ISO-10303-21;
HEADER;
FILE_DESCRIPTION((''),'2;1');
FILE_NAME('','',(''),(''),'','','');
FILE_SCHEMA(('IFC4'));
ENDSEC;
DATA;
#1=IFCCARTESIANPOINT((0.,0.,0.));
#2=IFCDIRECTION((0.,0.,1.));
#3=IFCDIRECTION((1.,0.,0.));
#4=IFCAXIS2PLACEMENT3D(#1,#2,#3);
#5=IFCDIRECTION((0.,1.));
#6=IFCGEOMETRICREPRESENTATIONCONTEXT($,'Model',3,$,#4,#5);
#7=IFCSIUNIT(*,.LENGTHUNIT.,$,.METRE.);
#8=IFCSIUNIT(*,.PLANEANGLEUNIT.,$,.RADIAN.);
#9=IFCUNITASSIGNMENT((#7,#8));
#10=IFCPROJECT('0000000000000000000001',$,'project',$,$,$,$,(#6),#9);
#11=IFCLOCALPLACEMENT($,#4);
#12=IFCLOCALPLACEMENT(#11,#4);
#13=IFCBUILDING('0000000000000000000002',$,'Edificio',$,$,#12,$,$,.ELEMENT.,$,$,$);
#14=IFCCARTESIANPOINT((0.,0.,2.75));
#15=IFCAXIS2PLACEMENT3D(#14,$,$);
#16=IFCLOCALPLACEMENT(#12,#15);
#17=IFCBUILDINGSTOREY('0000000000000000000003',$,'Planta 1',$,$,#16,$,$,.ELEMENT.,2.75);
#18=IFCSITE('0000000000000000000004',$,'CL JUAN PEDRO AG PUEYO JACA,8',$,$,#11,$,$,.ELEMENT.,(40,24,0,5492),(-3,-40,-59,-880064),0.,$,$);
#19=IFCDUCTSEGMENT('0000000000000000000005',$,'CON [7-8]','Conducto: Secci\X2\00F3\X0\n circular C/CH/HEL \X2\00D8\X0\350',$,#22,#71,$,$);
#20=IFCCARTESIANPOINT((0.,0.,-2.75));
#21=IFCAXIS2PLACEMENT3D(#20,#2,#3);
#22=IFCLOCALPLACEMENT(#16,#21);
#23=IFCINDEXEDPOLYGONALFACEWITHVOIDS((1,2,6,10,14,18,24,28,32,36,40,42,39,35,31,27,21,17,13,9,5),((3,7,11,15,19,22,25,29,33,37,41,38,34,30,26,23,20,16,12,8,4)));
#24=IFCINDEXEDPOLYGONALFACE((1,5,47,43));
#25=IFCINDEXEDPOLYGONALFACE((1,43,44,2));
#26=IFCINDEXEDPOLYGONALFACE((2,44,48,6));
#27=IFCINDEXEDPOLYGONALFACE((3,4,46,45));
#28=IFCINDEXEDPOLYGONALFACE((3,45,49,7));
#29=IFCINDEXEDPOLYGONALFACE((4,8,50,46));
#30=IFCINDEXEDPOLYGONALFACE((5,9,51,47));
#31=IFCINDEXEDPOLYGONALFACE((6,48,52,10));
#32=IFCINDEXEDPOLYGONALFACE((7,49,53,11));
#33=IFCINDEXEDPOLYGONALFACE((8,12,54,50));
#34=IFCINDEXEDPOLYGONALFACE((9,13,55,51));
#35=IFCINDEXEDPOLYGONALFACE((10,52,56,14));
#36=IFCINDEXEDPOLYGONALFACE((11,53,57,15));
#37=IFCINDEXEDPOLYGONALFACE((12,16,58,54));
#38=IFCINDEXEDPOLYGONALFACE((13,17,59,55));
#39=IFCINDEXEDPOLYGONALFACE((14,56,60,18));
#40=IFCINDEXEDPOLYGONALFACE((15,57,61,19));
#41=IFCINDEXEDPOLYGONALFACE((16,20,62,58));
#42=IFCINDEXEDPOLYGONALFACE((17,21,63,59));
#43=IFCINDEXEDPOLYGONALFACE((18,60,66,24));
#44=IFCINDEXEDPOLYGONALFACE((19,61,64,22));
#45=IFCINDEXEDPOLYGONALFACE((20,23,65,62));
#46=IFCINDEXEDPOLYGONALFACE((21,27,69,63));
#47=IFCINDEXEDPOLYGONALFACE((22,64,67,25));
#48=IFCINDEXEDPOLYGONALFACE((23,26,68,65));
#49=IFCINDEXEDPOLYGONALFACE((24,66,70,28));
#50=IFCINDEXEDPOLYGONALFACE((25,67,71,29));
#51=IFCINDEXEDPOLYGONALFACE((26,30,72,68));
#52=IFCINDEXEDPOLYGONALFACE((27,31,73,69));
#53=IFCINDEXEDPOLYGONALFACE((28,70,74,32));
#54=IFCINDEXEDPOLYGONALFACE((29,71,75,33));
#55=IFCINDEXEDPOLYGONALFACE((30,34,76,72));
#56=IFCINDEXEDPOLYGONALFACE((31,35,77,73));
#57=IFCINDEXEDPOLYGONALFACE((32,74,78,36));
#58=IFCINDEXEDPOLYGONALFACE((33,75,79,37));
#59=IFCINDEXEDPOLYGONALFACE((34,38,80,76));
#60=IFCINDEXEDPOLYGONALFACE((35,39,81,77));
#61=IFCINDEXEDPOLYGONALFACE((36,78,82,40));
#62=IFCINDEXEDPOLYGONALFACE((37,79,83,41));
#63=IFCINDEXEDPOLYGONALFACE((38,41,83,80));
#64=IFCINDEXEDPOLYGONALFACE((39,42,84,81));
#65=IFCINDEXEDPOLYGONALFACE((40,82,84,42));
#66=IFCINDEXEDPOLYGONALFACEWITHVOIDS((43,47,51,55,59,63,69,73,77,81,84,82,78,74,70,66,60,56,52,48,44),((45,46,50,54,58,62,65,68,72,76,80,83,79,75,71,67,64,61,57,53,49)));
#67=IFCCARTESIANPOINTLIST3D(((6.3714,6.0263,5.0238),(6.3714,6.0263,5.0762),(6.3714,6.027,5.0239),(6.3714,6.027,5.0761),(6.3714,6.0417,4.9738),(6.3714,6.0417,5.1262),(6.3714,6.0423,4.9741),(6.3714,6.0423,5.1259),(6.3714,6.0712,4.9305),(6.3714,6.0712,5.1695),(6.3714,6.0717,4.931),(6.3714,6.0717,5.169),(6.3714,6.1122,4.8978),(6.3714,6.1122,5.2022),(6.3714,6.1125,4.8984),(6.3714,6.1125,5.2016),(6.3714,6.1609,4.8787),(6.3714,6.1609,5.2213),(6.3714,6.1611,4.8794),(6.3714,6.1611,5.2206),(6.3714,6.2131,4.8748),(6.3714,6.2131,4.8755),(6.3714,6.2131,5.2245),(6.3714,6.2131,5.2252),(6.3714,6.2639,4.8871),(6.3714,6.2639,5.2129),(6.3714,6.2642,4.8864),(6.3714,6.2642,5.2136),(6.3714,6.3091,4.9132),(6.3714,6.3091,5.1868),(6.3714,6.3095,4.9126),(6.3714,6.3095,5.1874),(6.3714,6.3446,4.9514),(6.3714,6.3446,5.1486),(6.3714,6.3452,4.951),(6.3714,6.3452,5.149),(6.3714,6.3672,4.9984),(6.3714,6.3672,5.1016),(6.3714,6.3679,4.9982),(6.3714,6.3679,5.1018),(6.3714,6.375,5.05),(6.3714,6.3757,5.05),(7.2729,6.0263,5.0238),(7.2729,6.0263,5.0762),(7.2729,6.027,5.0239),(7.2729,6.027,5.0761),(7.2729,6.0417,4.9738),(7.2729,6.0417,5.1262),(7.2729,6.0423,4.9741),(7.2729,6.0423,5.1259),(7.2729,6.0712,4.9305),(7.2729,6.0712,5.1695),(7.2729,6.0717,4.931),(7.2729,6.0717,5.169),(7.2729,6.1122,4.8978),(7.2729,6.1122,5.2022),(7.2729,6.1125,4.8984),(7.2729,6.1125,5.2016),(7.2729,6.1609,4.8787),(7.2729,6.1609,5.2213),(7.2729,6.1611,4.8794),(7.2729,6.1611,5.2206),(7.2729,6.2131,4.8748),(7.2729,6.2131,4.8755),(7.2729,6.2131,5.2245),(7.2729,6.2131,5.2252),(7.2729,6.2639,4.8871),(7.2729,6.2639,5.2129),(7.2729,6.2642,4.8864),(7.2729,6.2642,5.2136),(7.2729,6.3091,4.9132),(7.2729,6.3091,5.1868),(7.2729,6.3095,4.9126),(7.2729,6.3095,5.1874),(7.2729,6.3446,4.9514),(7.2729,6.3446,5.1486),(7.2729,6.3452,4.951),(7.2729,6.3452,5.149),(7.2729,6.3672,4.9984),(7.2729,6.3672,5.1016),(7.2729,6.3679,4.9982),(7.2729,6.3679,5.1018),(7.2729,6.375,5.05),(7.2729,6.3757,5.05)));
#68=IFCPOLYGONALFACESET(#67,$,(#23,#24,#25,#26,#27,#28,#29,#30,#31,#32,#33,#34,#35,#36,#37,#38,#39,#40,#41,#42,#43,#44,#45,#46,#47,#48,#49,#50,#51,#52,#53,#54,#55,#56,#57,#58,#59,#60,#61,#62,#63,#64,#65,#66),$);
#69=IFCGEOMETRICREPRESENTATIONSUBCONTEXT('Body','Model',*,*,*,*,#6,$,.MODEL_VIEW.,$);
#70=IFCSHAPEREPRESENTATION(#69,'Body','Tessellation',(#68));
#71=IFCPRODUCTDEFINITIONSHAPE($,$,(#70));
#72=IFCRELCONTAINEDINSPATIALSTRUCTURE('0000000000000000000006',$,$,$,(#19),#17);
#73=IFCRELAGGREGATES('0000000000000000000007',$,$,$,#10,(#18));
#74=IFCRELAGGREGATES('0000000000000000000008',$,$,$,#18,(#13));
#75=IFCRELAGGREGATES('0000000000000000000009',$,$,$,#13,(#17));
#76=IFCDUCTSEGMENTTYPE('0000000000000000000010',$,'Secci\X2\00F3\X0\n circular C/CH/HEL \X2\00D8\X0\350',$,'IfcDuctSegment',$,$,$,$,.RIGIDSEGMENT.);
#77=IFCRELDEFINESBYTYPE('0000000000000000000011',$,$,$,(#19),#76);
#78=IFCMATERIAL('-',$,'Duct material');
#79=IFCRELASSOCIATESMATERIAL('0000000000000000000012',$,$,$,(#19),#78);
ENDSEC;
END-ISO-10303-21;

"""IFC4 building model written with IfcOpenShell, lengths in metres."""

from ifc_helpers import new_model, si_unit, direction, frame, origin_with_axes, origin_2d_with_axis, place, context, subcontext, project, spatial, hollow_circle, extrude, material, type_object, element, save


model = new_model("IFC4")

# Units and contexts
model_context = context("Model", 3, world=origin_with_axes(), true_north=direction((0.0, 1.0)))
body_context = subcontext(model_context, "Body", "Model", "MODEL_VIEW")
ifc_project = project(units=[si_unit("LENGTHUNIT", "METRE"), si_unit("PLANEANGLEUNIT", "RADIAN")], contexts=[model_context])

# Site, building, storey
site_placement = place(None, origin_with_axes())
site = spatial("IfcSite", under=ifc_project, at=site_placement, Name="CL JUAN PEDRO AG PUEYO JACA,8", CompositionType="ELEMENT", RefLatitude=(40, 24, 0, 5492), RefLongitude=(-3, -40, -59, -880064), RefElevation=0.0)
building_placement = place(site_placement, origin_with_axes())
building = spatial("IfcBuilding", under=site, at=building_placement, Name="Edificio", CompositionType="ELEMENT")
storey_placement = place(building_placement, frame((0.0, 0.0, 2.75)))
storey = spatial("IfcBuildingStorey", under=building, at=storey_placement, Name="Planta 1", CompositionType="ELEMENT", Elevation=2.75)

# Shared definitions
ifc_material_1 = material(Name="-", Category="Duct material")

# Duct segment
duct_segment_type_1 = type_object("IfcDuctSegmentType", Name="Sección circular C/CH/HEL Ø350", ApplicableOccurrence="IfcDuctSegment", PredefinedType="RIGIDSEGMENT")
duct_segment_1_placement = place(storey_placement, frame((0.0, 0.0, -2.75), z_axis=(0.0, 0.0, 1.0), x_axis=(1.0, 0.0, 0.0)))
element("IfcDuctSegment", 1, at=duct_segment_1_placement, inside=storey, type_object=duct_segment_type_1, material=ifc_material_1, Name="CON [7-8]", Description="Conducto: Sección circular C/CH/HEL Ø350", context=body_context, shape_type="SweptSolid", body=[
    extrude(hollow_circle(Radius=0.1757, WallThickness=0.0007, at=origin_2d_with_axis()), frame((6.3714, 6.2, 5.05), z_axis=(1.0, 0.0, 0.0), x_axis=(0.0, 1.0, 0.0)), (0.0, 0.0, 1.0), 0.9015),
])

save(model, "model.ifc")
